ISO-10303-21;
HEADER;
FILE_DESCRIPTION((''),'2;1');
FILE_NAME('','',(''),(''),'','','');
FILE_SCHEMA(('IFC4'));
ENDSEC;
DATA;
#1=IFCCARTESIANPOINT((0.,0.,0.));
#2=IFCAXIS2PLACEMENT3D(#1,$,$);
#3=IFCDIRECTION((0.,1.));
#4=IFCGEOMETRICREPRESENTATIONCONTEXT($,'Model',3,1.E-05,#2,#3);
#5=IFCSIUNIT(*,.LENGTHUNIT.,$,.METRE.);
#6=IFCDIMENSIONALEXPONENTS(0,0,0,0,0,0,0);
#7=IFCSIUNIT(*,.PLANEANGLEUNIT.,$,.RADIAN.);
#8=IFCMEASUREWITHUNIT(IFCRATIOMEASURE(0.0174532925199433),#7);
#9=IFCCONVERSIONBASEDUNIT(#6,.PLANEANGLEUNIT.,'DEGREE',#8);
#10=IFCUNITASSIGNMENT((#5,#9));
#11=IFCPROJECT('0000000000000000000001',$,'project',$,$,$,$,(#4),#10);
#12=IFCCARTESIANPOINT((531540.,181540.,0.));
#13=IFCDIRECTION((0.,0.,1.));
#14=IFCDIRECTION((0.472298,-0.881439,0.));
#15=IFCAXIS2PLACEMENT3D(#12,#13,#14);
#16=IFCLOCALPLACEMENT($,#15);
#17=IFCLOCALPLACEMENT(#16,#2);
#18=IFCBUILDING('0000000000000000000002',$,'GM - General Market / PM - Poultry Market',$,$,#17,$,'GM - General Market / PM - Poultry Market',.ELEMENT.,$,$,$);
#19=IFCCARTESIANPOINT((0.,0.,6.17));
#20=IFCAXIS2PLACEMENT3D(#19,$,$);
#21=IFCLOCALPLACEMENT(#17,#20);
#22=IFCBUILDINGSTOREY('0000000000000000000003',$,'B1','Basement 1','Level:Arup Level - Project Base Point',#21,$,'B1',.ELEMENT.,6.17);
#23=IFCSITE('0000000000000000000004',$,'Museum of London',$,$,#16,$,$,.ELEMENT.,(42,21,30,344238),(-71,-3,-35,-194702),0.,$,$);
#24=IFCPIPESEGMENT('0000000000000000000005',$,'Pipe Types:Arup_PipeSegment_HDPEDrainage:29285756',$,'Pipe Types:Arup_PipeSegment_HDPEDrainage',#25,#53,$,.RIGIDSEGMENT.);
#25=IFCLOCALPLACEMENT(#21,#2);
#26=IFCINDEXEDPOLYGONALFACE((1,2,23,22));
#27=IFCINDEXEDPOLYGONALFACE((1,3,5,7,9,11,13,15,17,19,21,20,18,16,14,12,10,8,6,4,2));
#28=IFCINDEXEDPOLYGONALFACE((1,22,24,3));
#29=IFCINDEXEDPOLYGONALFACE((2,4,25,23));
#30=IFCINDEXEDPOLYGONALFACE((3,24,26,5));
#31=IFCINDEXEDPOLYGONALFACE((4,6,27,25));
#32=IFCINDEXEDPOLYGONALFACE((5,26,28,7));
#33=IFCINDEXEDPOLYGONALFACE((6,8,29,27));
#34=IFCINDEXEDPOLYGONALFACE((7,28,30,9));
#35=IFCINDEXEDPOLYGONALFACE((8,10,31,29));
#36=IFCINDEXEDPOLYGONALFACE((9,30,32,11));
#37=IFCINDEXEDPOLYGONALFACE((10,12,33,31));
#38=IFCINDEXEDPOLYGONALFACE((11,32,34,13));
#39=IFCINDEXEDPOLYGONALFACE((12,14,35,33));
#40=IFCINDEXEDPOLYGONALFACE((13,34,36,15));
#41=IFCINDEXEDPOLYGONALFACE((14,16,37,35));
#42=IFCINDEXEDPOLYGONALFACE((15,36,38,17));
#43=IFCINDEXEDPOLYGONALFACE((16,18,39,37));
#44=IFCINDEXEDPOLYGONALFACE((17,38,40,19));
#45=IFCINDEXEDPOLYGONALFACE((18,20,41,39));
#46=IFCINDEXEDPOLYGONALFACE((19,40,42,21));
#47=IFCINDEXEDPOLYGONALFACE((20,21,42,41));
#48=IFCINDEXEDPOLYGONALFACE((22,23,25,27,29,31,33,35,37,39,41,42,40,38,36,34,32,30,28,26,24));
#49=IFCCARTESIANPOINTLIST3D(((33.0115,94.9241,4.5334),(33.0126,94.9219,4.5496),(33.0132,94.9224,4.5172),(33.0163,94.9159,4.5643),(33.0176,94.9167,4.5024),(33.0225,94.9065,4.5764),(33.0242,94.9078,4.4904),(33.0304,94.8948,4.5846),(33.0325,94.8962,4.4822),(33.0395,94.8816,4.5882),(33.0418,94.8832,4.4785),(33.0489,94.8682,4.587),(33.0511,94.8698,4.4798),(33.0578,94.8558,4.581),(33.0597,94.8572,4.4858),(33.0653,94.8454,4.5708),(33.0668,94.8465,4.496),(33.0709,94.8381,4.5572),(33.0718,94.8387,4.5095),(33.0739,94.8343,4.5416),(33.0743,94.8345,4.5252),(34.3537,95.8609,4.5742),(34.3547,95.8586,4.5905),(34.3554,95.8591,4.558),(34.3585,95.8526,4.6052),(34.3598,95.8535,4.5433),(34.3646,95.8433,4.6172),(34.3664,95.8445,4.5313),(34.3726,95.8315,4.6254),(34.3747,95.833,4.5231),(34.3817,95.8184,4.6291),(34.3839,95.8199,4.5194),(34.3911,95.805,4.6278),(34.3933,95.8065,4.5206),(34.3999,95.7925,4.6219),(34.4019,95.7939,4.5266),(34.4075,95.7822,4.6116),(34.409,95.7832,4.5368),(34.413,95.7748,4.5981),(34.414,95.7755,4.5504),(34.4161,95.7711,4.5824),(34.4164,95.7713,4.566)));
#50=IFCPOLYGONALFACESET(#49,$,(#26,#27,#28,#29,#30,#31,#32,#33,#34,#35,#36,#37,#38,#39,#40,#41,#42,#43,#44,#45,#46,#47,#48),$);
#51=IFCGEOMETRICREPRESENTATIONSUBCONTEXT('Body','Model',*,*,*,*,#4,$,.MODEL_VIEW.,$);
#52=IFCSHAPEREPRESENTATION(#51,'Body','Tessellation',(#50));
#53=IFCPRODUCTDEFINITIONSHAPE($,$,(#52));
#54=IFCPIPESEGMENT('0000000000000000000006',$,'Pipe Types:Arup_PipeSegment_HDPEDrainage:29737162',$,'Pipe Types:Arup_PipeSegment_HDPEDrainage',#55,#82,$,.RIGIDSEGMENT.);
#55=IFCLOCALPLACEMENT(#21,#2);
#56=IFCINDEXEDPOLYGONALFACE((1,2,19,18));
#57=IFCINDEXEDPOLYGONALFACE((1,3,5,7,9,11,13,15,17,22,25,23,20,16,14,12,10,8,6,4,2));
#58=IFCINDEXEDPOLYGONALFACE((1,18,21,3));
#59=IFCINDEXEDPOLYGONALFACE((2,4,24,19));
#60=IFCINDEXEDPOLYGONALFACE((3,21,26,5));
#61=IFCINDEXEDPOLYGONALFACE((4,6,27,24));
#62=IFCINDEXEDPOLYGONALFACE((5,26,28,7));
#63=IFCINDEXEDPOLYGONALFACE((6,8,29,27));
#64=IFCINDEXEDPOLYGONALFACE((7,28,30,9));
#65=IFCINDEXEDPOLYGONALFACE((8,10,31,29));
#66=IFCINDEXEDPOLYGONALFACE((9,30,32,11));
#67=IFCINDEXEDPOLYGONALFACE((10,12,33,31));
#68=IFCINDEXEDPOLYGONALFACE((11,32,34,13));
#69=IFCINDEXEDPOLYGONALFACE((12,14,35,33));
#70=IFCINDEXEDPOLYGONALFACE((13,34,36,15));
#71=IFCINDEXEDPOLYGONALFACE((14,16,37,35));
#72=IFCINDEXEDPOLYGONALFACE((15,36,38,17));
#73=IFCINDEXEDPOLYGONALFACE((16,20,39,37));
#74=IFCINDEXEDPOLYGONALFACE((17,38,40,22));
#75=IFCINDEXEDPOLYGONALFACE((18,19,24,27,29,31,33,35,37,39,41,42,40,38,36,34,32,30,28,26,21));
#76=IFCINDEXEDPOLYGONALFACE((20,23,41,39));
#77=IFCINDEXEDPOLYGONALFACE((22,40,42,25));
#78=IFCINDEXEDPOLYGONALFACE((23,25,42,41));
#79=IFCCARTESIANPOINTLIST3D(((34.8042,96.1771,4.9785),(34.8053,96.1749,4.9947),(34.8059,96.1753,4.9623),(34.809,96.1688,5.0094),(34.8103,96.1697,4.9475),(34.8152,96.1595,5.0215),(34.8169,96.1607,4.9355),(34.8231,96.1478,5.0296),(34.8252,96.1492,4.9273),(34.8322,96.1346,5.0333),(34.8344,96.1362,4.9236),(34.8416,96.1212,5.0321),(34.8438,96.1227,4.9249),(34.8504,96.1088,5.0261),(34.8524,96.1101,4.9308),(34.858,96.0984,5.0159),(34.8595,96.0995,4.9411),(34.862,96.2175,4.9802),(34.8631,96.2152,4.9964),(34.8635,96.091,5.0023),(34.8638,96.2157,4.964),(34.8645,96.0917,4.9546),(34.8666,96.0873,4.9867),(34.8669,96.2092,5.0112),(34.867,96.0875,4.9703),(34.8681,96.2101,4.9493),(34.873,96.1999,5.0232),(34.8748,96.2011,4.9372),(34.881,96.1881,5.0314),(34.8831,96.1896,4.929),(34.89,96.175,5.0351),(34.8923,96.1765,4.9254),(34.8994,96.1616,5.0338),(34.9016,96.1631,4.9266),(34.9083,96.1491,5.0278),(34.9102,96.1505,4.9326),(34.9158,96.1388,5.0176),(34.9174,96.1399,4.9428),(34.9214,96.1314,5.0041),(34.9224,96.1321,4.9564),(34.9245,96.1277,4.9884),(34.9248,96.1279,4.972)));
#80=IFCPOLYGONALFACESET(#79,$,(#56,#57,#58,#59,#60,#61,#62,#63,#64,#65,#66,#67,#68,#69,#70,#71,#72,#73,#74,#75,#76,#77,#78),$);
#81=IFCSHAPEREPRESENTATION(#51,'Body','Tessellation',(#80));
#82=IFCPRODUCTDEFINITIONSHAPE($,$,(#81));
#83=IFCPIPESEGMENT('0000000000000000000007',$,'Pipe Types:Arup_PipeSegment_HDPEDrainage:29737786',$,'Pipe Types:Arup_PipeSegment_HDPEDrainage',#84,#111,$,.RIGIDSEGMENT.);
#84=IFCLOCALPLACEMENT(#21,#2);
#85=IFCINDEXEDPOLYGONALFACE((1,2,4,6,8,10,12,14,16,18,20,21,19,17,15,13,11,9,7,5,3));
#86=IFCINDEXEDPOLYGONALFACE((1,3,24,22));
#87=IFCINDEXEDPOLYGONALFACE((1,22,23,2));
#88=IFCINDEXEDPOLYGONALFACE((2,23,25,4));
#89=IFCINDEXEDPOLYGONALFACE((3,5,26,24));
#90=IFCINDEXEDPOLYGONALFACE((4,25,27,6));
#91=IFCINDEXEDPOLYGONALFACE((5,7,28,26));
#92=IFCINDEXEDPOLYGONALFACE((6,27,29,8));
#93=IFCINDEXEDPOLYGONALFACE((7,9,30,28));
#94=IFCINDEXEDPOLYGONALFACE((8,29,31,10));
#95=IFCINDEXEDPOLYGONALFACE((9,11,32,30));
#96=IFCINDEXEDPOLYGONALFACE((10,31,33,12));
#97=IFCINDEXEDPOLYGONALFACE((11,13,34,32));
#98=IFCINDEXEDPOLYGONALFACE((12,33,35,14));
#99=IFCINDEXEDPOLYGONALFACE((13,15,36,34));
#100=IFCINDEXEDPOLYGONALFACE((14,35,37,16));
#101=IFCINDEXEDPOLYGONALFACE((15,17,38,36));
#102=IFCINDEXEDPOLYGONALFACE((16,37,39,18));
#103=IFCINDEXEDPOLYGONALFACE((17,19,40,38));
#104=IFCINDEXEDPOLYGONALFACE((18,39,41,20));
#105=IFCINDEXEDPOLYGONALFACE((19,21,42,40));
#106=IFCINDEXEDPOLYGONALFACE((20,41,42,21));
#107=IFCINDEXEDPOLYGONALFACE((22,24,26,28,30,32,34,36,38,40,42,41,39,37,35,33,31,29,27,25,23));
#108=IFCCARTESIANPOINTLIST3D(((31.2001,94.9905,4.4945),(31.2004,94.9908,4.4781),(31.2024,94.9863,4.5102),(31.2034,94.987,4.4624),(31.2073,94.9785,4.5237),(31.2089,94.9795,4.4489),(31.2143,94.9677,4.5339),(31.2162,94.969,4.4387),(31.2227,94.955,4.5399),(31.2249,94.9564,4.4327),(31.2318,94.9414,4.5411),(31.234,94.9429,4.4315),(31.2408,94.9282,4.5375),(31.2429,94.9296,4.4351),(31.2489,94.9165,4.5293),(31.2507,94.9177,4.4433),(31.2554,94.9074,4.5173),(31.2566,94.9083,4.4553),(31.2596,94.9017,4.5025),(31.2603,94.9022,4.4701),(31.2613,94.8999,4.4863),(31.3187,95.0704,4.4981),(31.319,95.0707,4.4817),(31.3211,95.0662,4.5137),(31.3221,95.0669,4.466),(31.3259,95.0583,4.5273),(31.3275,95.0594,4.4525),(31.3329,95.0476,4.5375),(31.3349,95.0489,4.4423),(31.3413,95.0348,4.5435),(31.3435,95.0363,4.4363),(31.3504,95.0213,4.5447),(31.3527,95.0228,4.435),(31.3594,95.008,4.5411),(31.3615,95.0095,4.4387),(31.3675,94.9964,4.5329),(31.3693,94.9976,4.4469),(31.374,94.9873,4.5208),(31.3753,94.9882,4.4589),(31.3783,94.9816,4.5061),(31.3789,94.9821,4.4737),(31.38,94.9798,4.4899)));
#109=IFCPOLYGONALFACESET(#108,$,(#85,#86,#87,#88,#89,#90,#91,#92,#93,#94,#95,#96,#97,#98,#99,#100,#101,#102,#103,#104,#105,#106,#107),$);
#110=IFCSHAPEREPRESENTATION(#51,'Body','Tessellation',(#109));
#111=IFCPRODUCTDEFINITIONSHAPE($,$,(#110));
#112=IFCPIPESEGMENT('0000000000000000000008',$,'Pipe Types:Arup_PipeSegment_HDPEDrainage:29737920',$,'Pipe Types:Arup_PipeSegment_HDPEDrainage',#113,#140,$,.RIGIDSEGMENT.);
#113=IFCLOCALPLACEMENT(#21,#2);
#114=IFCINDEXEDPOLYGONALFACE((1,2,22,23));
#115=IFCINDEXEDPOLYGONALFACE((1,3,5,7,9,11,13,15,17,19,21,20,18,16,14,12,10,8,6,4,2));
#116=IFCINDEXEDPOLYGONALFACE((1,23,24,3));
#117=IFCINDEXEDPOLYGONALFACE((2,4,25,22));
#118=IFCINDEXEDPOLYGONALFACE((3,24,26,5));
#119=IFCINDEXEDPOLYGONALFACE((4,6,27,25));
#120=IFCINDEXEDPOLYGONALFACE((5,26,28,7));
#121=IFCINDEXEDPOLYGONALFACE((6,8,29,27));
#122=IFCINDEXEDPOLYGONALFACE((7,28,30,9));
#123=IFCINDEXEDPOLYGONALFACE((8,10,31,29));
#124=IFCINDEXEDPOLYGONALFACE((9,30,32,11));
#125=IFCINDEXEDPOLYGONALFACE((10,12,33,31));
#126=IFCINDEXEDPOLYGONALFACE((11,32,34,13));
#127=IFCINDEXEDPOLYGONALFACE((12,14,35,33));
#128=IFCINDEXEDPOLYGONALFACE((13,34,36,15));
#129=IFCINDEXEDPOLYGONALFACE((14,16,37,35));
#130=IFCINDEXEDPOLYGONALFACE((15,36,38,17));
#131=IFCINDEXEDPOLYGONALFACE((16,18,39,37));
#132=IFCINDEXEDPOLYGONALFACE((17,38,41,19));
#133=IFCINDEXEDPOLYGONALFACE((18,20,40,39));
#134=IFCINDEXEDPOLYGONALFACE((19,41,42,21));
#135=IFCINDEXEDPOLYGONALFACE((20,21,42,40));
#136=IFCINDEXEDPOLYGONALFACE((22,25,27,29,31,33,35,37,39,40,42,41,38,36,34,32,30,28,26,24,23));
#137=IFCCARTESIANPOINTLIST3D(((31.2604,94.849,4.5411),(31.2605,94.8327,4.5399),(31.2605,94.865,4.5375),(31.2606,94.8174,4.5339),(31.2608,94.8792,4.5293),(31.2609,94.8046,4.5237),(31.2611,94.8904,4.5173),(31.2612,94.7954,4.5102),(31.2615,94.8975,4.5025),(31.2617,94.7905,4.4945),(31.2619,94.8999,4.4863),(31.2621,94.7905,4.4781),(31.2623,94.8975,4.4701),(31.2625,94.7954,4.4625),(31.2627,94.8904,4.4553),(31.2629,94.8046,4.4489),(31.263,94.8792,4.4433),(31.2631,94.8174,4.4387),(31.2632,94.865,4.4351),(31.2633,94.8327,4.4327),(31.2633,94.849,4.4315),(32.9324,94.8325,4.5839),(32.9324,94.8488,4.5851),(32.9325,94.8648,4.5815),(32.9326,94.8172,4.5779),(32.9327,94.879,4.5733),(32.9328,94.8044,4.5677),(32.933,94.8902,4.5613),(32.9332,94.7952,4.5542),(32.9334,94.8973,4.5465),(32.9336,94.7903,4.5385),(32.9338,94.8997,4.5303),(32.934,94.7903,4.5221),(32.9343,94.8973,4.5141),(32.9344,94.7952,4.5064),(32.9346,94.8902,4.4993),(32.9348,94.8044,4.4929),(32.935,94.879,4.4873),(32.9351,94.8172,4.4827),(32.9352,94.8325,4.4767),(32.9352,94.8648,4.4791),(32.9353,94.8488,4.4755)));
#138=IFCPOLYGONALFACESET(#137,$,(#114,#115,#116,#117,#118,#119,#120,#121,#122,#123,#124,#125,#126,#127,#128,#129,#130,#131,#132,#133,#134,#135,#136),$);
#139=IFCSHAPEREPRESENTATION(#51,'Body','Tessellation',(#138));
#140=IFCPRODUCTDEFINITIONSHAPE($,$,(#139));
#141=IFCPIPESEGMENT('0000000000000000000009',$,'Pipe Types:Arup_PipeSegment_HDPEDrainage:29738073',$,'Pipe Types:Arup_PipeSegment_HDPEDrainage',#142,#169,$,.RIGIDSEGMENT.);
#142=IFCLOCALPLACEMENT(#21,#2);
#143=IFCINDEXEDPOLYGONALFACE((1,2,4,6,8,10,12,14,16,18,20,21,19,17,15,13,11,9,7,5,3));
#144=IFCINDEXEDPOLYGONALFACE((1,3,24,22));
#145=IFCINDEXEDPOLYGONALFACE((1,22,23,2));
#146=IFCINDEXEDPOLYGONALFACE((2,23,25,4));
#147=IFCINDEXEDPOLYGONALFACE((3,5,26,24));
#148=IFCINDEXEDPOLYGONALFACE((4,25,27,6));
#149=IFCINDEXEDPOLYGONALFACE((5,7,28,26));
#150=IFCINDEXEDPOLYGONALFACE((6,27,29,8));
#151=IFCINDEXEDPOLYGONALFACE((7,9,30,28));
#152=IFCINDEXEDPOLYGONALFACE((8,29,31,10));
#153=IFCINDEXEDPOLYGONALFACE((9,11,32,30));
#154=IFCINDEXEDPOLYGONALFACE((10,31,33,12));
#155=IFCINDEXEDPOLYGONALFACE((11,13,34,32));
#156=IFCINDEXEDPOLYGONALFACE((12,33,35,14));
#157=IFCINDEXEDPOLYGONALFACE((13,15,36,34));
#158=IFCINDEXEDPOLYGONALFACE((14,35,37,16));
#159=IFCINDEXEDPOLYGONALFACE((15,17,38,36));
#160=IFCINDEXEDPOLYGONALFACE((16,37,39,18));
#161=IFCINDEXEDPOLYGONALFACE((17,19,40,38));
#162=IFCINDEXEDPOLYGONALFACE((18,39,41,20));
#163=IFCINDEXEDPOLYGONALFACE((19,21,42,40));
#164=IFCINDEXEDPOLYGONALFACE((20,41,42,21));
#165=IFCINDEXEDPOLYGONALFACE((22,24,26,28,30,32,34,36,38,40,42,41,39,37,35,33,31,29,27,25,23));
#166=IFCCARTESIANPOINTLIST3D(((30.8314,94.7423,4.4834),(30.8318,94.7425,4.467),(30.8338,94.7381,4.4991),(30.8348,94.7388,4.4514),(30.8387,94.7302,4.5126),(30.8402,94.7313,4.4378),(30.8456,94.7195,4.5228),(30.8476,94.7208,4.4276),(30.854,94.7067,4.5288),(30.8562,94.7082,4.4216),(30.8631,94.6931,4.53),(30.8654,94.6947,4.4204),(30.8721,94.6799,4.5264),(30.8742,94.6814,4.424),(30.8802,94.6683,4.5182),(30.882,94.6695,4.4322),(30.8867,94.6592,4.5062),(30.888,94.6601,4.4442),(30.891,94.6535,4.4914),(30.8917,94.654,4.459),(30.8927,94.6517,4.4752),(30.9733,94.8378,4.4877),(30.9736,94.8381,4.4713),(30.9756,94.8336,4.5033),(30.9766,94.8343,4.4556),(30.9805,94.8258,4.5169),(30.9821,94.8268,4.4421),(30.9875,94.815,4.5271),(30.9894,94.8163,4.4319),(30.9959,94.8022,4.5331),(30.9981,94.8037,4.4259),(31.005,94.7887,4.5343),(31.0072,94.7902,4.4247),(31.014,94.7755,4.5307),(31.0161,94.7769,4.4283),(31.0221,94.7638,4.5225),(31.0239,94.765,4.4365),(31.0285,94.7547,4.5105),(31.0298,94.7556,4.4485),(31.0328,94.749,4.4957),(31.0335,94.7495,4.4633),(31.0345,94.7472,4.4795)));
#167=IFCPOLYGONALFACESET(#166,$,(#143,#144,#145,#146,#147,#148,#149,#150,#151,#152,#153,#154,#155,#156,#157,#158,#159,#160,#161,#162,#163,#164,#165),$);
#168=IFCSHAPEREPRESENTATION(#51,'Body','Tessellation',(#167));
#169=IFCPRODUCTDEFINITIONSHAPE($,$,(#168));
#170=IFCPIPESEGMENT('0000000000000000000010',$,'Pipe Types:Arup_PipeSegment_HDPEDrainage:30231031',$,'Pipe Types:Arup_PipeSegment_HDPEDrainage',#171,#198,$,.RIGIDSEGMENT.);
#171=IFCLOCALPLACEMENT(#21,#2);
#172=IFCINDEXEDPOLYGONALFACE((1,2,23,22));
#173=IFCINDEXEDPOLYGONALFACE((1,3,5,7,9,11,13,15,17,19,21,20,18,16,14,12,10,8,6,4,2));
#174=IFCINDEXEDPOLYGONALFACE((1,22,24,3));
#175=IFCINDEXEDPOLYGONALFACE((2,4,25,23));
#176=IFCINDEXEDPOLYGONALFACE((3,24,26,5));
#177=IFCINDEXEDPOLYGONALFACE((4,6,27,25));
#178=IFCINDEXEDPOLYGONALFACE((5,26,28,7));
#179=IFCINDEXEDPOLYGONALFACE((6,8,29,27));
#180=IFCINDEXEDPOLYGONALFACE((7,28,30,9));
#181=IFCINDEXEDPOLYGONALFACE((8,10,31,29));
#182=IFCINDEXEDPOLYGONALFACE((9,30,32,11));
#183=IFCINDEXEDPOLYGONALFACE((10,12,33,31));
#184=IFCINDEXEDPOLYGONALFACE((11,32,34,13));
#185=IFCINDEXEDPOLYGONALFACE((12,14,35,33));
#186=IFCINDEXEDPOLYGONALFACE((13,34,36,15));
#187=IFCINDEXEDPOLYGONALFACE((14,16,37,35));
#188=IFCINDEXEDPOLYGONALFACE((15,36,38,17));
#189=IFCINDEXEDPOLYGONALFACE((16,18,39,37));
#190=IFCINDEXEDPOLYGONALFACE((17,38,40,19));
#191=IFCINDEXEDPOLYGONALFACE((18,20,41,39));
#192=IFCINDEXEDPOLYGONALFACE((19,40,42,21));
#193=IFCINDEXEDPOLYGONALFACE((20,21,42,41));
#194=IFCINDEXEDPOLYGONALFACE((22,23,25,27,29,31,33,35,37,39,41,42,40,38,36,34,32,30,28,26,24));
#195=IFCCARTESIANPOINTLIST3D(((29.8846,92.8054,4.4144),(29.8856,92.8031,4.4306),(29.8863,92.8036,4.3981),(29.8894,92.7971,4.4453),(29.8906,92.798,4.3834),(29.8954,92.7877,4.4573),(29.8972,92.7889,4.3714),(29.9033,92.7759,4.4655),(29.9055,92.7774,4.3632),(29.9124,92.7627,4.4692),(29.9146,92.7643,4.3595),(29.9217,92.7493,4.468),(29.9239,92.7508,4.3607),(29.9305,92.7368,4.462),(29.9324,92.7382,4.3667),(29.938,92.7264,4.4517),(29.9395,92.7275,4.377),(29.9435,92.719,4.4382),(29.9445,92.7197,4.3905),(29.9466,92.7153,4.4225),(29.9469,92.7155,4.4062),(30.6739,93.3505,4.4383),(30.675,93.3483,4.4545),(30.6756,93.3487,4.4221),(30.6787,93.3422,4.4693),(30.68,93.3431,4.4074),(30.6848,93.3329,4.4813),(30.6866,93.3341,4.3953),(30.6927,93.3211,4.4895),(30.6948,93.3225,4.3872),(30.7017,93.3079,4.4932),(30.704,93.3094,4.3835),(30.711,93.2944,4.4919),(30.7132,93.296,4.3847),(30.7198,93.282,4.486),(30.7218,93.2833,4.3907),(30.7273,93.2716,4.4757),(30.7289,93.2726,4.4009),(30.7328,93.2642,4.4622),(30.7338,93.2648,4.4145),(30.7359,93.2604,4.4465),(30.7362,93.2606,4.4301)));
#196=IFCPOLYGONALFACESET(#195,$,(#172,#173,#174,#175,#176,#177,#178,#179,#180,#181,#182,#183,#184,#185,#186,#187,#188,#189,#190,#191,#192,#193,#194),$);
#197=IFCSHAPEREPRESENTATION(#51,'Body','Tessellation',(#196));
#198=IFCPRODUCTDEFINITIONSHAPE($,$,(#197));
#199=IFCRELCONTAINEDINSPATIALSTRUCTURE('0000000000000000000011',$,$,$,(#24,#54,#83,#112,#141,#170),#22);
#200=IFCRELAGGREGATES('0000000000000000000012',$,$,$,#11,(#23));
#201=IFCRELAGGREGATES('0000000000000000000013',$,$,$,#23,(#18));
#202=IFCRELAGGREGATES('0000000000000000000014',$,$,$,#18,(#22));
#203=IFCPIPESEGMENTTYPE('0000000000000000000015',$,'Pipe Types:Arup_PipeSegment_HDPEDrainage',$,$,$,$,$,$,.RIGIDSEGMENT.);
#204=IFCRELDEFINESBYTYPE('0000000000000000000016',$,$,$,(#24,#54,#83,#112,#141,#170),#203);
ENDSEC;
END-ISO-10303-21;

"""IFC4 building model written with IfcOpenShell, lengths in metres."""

from ifc_helpers import new_model, entity, si_unit, converted_unit, direction, frame, frame_2d, origin, origin_2d_with_axis, place, context, subcontext, project, spatial, circle, extrude, type_object, element, save


model = new_model("IFC4")

# Units and contexts
model_context = context("Model", 3, precision=1e-05, world=origin(), true_north=direction((0.0, 1.0)))
body_context = subcontext(model_context, "Body", "Model", "MODEL_VIEW")
ifc_project = project(units=[si_unit("LENGTHUNIT", "METRE"), converted_unit("PLANEANGLEUNIT", "DEGREE", entity("IfcRatioMeasure", 0.0174532925199433), si_unit("PLANEANGLEUNIT", "RADIAN"), dimensions=[0, 0, 0, 0, 0, 0, 0])], contexts=[model_context])

# Site, building, storey
site_placement = place(None, frame((531540.0, 181540.0, 0.0), z_axis=(0.0, 0.0, 1.0), x_axis=(0.472298, -0.881439, 0.0)))
site = spatial("IfcSite", under=ifc_project, at=site_placement, Name="Museum of London", CompositionType="ELEMENT", RefLatitude=(42, 21, 30, 344238), RefLongitude=(-71, -3, -35, -194702), RefElevation=0.0)
building_placement = place(site_placement, origin())
building = spatial("IfcBuilding", under=site, at=building_placement, Name="GM - General Market / PM - Poultry Market", LongName="GM - General Market / PM - Poultry Market", CompositionType="ELEMENT")
storey_placement = place(building_placement, frame((0.0, 0.0, 6.17)))
storey = spatial("IfcBuildingStorey", under=building, at=storey_placement, Name="B1", Description="Basement 1", ObjectType="Level:Arup Level - Project Base Point", LongName="B1", CompositionType="ELEMENT", Elevation=6.17)

# Pipe segments
pipe_segment_type_1 = type_object("IfcPipeSegmentType", Name="Pipe Types:Arup_PipeSegment_HDPEDrainage", PredefinedType="RIGIDSEGMENT")
pipe_segment_1_placement = place(storey_placement, frame((33.0099, 94.8323, 4.4768)))
element("IfcPipeSegment", 1, at=pipe_segment_1_placement, inside=storey, type_object=pipe_segment_type_1, Name="Pipe Types:Arup_PipeSegment_HDPEDrainage:29285756", ObjectType="Pipe Types:Arup_PipeSegment_HDPEDrainage", PredefinedType="RIGIDSEGMENT", context=body_context, shape_type="SweptSolid", body=[
    extrude(circle(Radius=0.055, at=frame_2d((0.0, 0.0), x_axis=(1.0, 0.0))), frame((0.0331, 0.0467, 0.0566), z_axis=(0.819771, 0.572147, 0.024964), x_axis=(-0.572325, 0.820027, 0.0)), (0.0, 0.0, 1.0), 1.6372),
])
pipe_segment_2_placement = place(storey_placement, frame((34.8026, 96.0853, 4.9219)))
element("IfcPipeSegment", 2, at=pipe_segment_2_placement, inside=storey, type_object=pipe_segment_type_1, Name="Pipe Types:Arup_PipeSegment_HDPEDrainage:29737162", ObjectType="Pipe Types:Arup_PipeSegment_HDPEDrainage", PredefinedType="RIGIDSEGMENT", context=body_context, shape_type="SweptSolid", body=[
    extrude(circle(Radius=0.055, at=frame_2d((0.0, 0.0), x_axis=(1.0, 0.0))), frame((0.0331, 0.0467, 0.0566), z_axis=(0.819771, 0.572146, 0.024997), x_axis=(-0.572325, 0.820027, 0.0)), (0.0, 0.0, 1.0), 0.0706),
])
pipe_segment_3_placement = place(storey_placement, frame((31.1983, 94.8983, 4.4297)))
element("IfcPipeSegment", 3, at=pipe_segment_3_placement, inside=storey, type_object=pipe_segment_type_1, Name="Pipe Types:Arup_PipeSegment_HDPEDrainage:29737786", ObjectType="Pipe Types:Arup_PipeSegment_HDPEDrainage", PredefinedType="RIGIDSEGMENT", context=body_context, shape_type="SweptSolid", body=[
    extrude(circle(Radius=0.055, at=origin_2d_with_axis()), frame((0.0323, 0.0472, 0.0566), z_axis=(0.829225, 0.558357, 0.024951), x_axis=(0.558531, -0.829484, 0.0)), (0.0, 0.0, 1.0), 0.1431),
])
pipe_segment_4_placement = place(storey_placement, frame((31.2588, 94.7881, 4.4297)))
element("IfcPipeSegment", 4, at=pipe_segment_4_placement, inside=storey, type_object=pipe_segment_type_1, Name="Pipe Types:Arup_PipeSegment_HDPEDrainage:29737920", ObjectType="Pipe Types:Arup_PipeSegment_HDPEDrainage", PredefinedType="RIGIDSEGMENT", context=body_context, shape_type="SweptSolid", body=[
    extrude(circle(Radius=0.055, at=origin_2d_with_axis()), frame((0.003, 0.0568, 0.0566), z_axis=(0.999654, -0.000131, 0.026297), x_axis=(0.000131, 1.0, 0.0)), (0.0, 0.0, 1.0), 1.6725),
])
pipe_segment_5_placement = place(storey_placement, frame((30.8296, 94.6501, 4.4186)))
element("IfcPipeSegment", 5, at=pipe_segment_5_placement, inside=storey, type_object=pipe_segment_type_1, Name="Pipe Types:Arup_PipeSegment_HDPEDrainage:29738073", ObjectType="Pipe Types:Arup_PipeSegment_HDPEDrainage", PredefinedType="RIGIDSEGMENT", context=body_context, shape_type="SweptSolid", body=[
    extrude(circle(Radius=0.055, at=origin_2d_with_axis()), frame((0.0323, 0.0472, 0.0566), z_axis=(0.829225, 0.558357, 0.024951), x_axis=(0.558531, -0.829484, 0.0)), (0.0, 0.0, 1.0), 0.1711),
])
pipe_segment_6_placement = place(storey_placement, frame((29.883, 92.7133, 4.3578)))
element("IfcPipeSegment", 6, at=pipe_segment_6_placement, inside=storey, type_object=pipe_segment_type_1, Name="Pipe Types:Arup_PipeSegment_HDPEDrainage:30231031", ObjectType="Pipe Types:Arup_PipeSegment_HDPEDrainage", PredefinedType="RIGIDSEGMENT", context=body_context, shape_type="SweptSolid", body=[
    extrude(circle(Radius=0.055, at=origin_2d_with_axis()), frame((0.0329, 0.0469, 0.0566), z_axis=(0.822584, 0.568094, 0.024995), x_axis=(-0.568271, 0.822841, 0.0)), (0.0, 0.0, 1.0), 0.9596),
])

save(model, "model.ifc")
